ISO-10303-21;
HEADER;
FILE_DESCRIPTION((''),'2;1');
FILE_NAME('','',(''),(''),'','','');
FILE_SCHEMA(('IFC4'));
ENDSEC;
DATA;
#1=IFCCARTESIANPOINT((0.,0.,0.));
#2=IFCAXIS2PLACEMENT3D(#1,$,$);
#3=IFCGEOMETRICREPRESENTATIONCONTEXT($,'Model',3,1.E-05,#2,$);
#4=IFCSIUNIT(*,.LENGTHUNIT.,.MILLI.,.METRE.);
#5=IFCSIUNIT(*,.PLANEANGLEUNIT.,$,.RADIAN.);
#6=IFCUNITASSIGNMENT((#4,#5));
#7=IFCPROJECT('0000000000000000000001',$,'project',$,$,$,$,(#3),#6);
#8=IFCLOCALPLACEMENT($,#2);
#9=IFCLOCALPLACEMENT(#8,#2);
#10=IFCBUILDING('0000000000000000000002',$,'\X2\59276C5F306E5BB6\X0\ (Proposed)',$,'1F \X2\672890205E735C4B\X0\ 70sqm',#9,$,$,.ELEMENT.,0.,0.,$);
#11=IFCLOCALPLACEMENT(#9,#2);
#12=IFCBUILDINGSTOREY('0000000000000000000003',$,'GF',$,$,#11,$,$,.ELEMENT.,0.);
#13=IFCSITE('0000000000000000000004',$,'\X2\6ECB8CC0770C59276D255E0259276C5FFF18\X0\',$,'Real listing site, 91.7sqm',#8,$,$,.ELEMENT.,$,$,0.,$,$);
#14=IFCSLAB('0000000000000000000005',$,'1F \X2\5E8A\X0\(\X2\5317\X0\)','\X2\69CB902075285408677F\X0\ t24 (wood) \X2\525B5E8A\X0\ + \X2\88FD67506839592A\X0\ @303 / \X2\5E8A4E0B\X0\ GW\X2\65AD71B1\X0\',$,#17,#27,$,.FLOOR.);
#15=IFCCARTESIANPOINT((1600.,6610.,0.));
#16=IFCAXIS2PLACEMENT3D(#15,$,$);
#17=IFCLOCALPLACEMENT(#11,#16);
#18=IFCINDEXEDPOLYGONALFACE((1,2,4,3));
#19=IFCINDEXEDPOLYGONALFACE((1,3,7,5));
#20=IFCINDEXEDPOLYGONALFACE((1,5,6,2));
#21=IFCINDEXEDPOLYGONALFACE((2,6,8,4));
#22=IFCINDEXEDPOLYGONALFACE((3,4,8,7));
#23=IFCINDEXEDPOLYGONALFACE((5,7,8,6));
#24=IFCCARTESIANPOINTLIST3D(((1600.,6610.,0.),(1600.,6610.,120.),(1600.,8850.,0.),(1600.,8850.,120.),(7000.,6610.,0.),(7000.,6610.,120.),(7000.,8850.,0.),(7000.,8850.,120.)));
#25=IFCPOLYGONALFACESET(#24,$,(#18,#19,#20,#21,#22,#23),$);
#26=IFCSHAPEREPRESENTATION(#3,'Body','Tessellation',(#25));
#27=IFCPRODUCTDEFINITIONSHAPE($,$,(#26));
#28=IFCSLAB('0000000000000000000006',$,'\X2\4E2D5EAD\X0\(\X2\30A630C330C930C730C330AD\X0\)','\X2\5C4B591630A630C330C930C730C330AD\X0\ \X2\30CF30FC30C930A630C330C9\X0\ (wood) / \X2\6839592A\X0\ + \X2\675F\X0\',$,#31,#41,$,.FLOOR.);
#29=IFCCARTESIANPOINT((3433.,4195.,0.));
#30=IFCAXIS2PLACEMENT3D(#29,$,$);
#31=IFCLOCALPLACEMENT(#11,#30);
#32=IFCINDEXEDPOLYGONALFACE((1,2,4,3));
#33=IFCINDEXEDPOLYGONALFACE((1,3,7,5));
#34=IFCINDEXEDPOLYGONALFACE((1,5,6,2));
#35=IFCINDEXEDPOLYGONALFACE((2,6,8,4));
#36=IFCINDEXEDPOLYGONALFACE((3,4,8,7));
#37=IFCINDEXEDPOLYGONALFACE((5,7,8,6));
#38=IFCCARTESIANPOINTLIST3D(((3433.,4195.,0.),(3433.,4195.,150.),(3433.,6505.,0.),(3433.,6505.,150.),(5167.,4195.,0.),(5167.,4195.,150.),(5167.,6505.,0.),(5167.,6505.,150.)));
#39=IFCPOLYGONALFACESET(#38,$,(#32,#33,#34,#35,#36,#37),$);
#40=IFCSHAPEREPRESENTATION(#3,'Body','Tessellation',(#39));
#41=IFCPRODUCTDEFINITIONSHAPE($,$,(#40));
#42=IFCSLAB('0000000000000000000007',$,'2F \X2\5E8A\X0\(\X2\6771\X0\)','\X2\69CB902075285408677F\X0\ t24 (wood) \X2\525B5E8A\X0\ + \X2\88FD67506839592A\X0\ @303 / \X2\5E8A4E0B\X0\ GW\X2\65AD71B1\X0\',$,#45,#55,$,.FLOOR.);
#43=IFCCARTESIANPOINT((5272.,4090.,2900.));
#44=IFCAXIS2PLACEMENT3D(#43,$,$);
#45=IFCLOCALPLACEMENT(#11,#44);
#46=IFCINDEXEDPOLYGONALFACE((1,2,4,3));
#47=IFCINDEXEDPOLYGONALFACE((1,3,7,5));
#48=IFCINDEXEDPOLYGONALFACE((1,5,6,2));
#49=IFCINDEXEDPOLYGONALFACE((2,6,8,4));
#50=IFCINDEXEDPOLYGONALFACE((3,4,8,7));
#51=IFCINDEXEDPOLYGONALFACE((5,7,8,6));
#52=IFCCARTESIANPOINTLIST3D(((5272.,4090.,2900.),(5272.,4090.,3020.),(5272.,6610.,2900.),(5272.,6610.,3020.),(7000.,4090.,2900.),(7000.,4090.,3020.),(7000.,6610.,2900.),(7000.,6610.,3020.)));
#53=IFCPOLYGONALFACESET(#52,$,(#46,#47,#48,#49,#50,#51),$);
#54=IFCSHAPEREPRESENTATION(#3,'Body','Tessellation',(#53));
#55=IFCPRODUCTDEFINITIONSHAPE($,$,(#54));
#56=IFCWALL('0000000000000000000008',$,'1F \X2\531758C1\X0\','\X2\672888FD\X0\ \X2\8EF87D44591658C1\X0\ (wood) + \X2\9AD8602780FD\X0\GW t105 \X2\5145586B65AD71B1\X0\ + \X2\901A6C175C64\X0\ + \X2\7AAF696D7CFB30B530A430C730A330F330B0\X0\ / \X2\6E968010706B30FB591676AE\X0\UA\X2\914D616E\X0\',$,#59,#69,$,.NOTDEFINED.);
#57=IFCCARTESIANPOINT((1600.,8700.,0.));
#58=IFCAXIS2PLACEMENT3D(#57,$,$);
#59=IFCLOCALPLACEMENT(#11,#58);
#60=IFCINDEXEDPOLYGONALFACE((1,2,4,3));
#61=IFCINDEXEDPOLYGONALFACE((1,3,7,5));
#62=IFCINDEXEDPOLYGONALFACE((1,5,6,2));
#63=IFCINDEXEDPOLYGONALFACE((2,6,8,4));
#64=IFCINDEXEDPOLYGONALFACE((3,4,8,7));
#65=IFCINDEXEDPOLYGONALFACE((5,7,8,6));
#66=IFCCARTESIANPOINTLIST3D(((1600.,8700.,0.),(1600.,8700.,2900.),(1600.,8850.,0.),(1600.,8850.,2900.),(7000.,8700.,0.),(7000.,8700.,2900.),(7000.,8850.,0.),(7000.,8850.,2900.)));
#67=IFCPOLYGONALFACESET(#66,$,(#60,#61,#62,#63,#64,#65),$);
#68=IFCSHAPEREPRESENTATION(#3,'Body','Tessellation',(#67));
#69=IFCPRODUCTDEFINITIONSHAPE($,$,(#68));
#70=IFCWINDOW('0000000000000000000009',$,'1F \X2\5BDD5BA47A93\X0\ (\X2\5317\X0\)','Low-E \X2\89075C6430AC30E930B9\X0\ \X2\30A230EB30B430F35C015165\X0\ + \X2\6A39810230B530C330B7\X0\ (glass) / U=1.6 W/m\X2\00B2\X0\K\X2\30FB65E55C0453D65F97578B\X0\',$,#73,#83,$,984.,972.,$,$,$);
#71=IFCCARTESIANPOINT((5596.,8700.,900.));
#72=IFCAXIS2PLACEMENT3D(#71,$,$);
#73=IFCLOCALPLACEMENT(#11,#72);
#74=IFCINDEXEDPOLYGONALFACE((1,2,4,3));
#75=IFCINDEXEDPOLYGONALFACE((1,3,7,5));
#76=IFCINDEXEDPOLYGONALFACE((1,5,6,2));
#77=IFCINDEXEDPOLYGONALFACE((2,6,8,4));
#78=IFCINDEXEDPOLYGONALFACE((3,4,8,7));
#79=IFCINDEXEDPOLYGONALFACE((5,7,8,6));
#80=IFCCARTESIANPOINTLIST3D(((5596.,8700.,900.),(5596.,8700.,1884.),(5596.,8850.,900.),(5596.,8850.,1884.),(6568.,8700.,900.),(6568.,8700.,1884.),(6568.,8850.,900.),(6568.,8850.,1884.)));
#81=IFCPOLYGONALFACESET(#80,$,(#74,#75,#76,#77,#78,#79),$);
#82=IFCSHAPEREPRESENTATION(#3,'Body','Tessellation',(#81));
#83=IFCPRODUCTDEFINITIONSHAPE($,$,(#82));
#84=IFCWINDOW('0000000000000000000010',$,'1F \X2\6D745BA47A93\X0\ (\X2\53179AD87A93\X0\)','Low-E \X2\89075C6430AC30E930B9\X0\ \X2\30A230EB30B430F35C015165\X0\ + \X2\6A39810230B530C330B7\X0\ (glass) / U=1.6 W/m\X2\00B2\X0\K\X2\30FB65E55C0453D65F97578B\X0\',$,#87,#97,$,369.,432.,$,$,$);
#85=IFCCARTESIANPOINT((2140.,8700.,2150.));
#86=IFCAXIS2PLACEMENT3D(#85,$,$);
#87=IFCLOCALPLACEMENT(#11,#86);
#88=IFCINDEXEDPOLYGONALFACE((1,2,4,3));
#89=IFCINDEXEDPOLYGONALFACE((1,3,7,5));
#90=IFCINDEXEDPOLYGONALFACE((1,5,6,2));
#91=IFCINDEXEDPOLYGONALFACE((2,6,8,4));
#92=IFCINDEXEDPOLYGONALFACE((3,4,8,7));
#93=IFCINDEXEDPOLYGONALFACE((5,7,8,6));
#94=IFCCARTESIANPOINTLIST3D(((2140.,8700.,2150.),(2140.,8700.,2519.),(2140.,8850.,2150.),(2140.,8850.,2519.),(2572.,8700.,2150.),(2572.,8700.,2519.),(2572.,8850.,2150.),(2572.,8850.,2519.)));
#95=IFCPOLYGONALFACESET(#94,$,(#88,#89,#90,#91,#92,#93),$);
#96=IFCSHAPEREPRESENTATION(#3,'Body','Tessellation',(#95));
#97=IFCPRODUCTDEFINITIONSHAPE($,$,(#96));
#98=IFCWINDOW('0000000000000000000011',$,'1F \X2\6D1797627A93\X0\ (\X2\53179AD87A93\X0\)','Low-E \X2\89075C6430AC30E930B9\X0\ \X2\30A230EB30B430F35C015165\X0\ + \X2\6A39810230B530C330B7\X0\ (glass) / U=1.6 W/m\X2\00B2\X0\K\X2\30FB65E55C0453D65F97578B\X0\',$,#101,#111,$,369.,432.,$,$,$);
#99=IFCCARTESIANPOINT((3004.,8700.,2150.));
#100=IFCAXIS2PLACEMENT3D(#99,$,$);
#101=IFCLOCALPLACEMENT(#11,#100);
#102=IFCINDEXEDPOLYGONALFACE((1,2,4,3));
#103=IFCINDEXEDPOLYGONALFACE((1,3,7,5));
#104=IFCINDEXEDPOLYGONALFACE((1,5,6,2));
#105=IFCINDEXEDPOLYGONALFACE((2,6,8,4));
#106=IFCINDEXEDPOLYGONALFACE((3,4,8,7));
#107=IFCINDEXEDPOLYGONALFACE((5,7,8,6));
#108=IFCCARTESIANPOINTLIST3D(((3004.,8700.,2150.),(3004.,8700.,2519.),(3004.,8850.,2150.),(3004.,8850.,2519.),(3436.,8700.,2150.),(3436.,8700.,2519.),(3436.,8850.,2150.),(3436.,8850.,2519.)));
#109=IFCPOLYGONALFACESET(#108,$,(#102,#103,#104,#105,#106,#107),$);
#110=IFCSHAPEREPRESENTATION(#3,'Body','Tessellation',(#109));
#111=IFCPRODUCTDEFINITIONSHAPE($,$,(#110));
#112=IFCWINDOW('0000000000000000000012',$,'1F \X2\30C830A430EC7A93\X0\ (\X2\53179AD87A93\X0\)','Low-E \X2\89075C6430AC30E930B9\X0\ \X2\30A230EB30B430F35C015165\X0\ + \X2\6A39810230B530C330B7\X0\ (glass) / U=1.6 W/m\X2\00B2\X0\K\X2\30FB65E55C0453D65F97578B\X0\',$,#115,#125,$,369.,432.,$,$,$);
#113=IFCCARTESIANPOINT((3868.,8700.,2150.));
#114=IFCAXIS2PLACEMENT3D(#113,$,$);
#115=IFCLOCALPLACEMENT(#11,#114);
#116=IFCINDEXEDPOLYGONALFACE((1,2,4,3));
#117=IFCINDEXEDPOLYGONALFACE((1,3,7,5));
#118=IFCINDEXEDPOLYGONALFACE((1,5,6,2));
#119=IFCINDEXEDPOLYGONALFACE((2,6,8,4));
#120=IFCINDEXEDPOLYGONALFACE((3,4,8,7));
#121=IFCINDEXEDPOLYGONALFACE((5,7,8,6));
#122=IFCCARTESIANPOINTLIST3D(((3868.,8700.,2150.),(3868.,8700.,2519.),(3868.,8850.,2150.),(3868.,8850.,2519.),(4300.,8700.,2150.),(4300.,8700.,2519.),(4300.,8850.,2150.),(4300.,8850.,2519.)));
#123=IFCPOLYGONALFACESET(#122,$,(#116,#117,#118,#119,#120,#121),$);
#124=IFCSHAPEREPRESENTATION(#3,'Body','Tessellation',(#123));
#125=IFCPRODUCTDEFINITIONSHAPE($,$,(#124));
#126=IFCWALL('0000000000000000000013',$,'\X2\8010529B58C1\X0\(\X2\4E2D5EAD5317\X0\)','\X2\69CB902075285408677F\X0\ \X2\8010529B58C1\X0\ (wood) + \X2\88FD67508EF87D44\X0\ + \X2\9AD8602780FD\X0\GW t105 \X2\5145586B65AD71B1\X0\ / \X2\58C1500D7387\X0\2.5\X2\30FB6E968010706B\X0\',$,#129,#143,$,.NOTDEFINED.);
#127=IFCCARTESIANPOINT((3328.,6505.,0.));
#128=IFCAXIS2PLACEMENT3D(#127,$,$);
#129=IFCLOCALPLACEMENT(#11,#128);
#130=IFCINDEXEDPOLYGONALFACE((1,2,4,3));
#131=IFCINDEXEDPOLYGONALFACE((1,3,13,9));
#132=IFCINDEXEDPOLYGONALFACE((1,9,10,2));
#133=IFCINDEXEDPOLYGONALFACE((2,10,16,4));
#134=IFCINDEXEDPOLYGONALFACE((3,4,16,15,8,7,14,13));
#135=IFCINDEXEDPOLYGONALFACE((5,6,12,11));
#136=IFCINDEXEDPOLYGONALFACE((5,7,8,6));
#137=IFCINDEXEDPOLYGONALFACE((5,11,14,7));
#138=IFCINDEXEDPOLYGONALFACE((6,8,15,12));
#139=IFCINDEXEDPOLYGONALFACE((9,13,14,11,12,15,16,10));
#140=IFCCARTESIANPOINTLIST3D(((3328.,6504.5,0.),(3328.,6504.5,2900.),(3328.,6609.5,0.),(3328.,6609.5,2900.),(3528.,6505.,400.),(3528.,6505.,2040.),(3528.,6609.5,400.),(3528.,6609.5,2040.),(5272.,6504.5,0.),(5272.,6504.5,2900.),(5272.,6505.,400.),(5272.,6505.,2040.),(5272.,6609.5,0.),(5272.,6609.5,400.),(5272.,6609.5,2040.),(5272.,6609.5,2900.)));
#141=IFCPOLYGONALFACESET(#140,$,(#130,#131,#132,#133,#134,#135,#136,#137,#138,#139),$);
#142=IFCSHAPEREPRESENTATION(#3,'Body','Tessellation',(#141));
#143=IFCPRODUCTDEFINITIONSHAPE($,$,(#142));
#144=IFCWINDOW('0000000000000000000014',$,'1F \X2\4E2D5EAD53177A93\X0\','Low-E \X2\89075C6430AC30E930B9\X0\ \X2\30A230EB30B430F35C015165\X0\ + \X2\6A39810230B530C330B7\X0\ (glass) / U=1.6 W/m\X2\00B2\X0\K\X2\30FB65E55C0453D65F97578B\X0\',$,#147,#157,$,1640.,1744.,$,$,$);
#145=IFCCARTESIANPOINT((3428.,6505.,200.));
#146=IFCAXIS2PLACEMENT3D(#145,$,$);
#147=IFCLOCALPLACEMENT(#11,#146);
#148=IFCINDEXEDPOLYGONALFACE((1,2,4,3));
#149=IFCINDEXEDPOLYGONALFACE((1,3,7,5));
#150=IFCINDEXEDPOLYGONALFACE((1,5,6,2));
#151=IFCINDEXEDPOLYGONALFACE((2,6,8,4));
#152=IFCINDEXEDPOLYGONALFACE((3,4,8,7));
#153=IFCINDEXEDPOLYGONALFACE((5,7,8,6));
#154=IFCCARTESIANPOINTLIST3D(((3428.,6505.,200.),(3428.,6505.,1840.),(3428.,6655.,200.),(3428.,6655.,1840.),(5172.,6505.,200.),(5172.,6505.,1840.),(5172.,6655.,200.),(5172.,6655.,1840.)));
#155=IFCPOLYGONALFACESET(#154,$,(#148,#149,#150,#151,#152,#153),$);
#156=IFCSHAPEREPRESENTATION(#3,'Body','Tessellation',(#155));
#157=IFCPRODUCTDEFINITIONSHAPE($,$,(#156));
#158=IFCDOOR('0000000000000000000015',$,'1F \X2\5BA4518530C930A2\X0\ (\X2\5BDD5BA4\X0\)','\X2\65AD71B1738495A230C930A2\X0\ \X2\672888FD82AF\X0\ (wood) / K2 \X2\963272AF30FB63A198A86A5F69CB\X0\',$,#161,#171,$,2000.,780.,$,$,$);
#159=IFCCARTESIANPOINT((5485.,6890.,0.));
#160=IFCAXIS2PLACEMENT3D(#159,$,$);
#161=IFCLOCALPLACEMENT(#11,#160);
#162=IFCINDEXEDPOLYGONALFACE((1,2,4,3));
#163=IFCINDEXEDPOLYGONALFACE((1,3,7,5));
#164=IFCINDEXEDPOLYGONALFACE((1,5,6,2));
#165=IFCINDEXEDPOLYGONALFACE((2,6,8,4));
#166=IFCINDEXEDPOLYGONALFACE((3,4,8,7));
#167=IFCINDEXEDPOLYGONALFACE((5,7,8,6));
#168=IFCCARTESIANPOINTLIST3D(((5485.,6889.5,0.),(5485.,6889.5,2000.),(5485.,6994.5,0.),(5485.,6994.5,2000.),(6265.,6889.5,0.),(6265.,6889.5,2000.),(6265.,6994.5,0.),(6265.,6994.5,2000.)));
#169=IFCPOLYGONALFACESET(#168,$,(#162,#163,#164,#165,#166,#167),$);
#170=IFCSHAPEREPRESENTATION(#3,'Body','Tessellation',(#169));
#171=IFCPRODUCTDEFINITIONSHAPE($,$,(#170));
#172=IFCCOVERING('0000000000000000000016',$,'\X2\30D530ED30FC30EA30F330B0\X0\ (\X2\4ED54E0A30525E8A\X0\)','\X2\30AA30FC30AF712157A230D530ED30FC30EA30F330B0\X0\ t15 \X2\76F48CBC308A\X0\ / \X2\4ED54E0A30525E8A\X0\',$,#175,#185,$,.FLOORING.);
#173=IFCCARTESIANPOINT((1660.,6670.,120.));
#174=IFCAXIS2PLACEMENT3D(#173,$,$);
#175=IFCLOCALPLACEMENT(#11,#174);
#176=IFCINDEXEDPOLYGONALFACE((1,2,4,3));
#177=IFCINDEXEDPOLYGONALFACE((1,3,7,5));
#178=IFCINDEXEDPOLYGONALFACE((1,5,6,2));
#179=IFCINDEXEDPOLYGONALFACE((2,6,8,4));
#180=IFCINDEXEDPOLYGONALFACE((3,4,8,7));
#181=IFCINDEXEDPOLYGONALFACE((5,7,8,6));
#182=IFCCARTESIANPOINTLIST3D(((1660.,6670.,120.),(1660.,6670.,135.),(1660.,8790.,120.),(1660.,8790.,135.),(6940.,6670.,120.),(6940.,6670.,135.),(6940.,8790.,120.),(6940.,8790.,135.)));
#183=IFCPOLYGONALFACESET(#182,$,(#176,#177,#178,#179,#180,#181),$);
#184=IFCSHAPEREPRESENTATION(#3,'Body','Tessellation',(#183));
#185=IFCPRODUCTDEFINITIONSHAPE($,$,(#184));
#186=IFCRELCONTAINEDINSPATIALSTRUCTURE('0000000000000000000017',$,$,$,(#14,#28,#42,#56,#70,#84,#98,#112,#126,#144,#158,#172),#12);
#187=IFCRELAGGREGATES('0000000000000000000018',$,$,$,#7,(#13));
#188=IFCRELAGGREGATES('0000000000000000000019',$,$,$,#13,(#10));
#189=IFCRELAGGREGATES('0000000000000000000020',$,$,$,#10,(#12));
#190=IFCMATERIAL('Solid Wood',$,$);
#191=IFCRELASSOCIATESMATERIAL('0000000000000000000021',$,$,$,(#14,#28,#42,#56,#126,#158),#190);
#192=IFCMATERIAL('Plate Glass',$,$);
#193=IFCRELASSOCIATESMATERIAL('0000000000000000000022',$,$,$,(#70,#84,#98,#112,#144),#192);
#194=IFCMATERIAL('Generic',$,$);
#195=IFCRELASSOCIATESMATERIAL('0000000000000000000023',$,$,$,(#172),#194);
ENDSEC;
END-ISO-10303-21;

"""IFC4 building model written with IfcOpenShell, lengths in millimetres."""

from ifc_helpers import new_model, si_unit, frame, frame_2d, origin, place, context, project, spatial, rectangle, extrude, material, element, fill, save


model = new_model("IFC4")

# Units and contexts
model_context = context("Model", 3, precision=1e-05, world=origin())
ifc_project = project(units=[si_unit("LENGTHUNIT", "METRE", prefix="MILLI"), si_unit("PLANEANGLEUNIT", "RADIAN")], contexts=[model_context])

# Site, building, storey
site_placement = place(None, origin())
site = spatial("IfcSite", under=ifc_project, at=site_placement, Name="滋賀県大津市大江８", ObjectType="Real listing site, 91.7sqm", CompositionType="ELEMENT", RefElevation=0.0)
building_placement = place(site_placement, origin())
building = spatial("IfcBuilding", under=site, at=building_placement, Name="大江の家 (Proposed)", ObjectType="1F 木造平屋 70sqm", CompositionType="ELEMENT", ElevationOfRefHeight=0.0, ElevationOfTerrain=0.0)
storey_placement = place(building_placement, origin())
storey = spatial("IfcBuildingStorey", under=building, at=storey_placement, Name="GF", CompositionType="ELEMENT", Elevation=0.0)

# Slabs
ifc_material_1 = material(Name="Solid Wood")
slab_1_placement = place(storey_placement, frame((1600.0, 6610.0, 0.0)))
element("IfcSlab", 1, at=slab_1_placement, inside=storey, material=ifc_material_1, Name="1F 床(北)", Description="構造用合板 t24 (wood) 剛床 + 製材根太 @303 / 床下 GW断熱", PredefinedType="FLOOR", context=model_context, shape_type="SweptSolid", body=[
    extrude(rectangle(XDim=5400.0, YDim=2240.0, at=frame_2d((2700.0, 1120.0))), frame((1600.0, 6610.0, 0.0)), (0.0, 0.0, 1.0), 120.0),
])
slab_2_placement = place(storey_placement, frame((3433.0, 4195.0, 0.0)))
element("IfcSlab", 2, at=slab_2_placement, inside=storey, material=ifc_material_1, Name="中庭(ウッドデッキ)", Description="屋外ウッドデッキ ハードウッド (wood) / 根太 + 束", PredefinedType="FLOOR", context=model_context, shape_type="SweptSolid", body=[
    extrude(rectangle(XDim=1734.0, YDim=2310.0, at=frame_2d((867.0, 1155.0))), frame((3433.0, 4195.0, 0.0)), (0.0, 0.0, 1.0), 150.0),
])
slab_3_placement = place(storey_placement, frame((5272.0, 4090.0, 2900.0)))
element("IfcSlab", 3, at=slab_3_placement, inside=storey, material=ifc_material_1, Name="2F 床(東)", Description="構造用合板 t24 (wood) 剛床 + 製材根太 @303 / 床下 GW断熱", PredefinedType="FLOOR", context=model_context, shape_type="SweptSolid", body=[
    extrude(rectangle(XDim=1728.0, YDim=2520.0, at=frame_2d((864.0, 1260.0))), frame((5272.0, 4090.0, 2900.0)), (0.0, 0.0, 1.0), 120.0),
])

# Wall, openings, windows
wall_1_placement = place(storey_placement, frame((1600.0, 8700.0, 0.0)))
wall_1 = element("IfcWall", 4, at=wall_1_placement, inside=storey, material=ifc_material_1, Name="1F 北壁", Description="木製 軸組外壁 (wood) + 高性能GW t105 充填断熱 + 通気層 + 窯業系サイディング / 準耐火・外皮UA配慮", PredefinedType="NOTDEFINED", context=model_context, shape_type="SweptSolid", body=[
    extrude(rectangle(XDim=5400.0, YDim=150.0, at=frame_2d((2700.0, 75.0))), frame((1600.0, 8700.0, 0.0)), (0.0, 0.0, 1.0), 2900.0),
])
opening_1_placement = place(storey_placement, frame((5596.0, 8700.0, 900.0)))
opening_1 = element("IfcOpeningElement", 5, at=opening_1_placement, cuts=wall_1, PredefinedType="NOTDEFINED", context=model_context, shape_type="SweptSolid", body=[
    extrude(rectangle(XDim=972.0, YDim=150.0, at=frame_2d((486.0, 75.0))), frame((5596.0, 8700.0, 900.0)), (0.0, 0.0, 1.0), 984.0),
])
opening_2_placement = place(storey_placement, frame((2140.0, 8700.0, 2150.0)))
opening_2 = element("IfcOpeningElement", 6, at=opening_2_placement, cuts=wall_1, PredefinedType="NOTDEFINED", context=model_context, shape_type="SweptSolid", body=[
    extrude(rectangle(XDim=432.0, YDim=150.0, at=frame_2d((216.0, 75.0))), frame((2140.0, 8700.0, 2150.0)), (0.0, 0.0, 1.0), 369.0),
])
opening_3_placement = place(storey_placement, frame((3004.0, 8700.0, 2150.0)))
opening_3 = element("IfcOpeningElement", 7, at=opening_3_placement, cuts=wall_1, PredefinedType="NOTDEFINED", context=model_context, shape_type="SweptSolid", body=[
    extrude(rectangle(XDim=432.0, YDim=150.0, at=frame_2d((216.0, 75.0))), frame((3004.0, 8700.0, 2150.0)), (0.0, 0.0, 1.0), 369.0),
])
opening_4_placement = place(storey_placement, frame((3868.0, 8700.0, 2150.0)))
opening_4 = element("IfcOpeningElement", 8, at=opening_4_placement, cuts=wall_1, PredefinedType="NOTDEFINED", context=model_context, shape_type="SweptSolid", body=[
    extrude(rectangle(XDim=432.0, YDim=150.0, at=frame_2d((216.0, 75.0))), frame((3868.0, 8700.0, 2150.0)), (0.0, 0.0, 1.0), 369.0),
])
ifc_material_2 = material(Name="Plate Glass")
window_1_placement = place(storey_placement, frame((5596.0, 8700.0, 900.0)))
window_1 = element("IfcWindow", 9, at=window_1_placement, inside=storey, material=ifc_material_2, Name="1F 寝室窓 (北)", Description="Low-E 複層ガラス アルゴン封入 + 樹脂サッシ (glass) / U=1.6 W/m²K・日射取得型", OverallHeight=984.0, OverallWidth=972.0, context=model_context, shape_type="SweptSolid", body=[
    extrude(rectangle(XDim=972.0, YDim=150.0, at=frame_2d((486.0, 75.0))), frame((5596.0, 8700.0, 900.0)), (0.0, 0.0, 1.0), 984.0),
])
fill(opening_1, window_1)
window_2_placement = place(storey_placement, frame((2140.0, 8700.0, 2150.0)))
window_2 = element("IfcWindow", 10, at=window_2_placement, inside=storey, material=ifc_material_2, Name="1F 浴室窓 (北高窓)", Description="Low-E 複層ガラス アルゴン封入 + 樹脂サッシ (glass) / U=1.6 W/m²K・日射取得型", OverallHeight=369.0, OverallWidth=432.0, context=model_context, shape_type="SweptSolid", body=[
    extrude(rectangle(XDim=432.0, YDim=150.0, at=frame_2d((216.0, 75.0))), frame((2140.0, 8700.0, 2150.0)), (0.0, 0.0, 1.0), 369.0),
])
fill(opening_2, window_2)
window_3_placement = place(storey_placement, frame((3004.0, 8700.0, 2150.0)))
window_3 = element("IfcWindow", 11, at=window_3_placement, inside=storey, material=ifc_material_2, Name="1F 洗面窓 (北高窓)", Description="Low-E 複層ガラス アルゴン封入 + 樹脂サッシ (glass) / U=1.6 W/m²K・日射取得型", OverallHeight=369.0, OverallWidth=432.0, context=model_context, shape_type="SweptSolid", body=[
    extrude(rectangle(XDim=432.0, YDim=150.0, at=frame_2d((216.0, 75.0))), frame((3004.0, 8700.0, 2150.0)), (0.0, 0.0, 1.0), 369.0),
])
fill(opening_3, window_3)
window_4_placement = place(storey_placement, frame((3868.0, 8700.0, 2150.0)))
window_4 = element("IfcWindow", 12, at=window_4_placement, inside=storey, material=ifc_material_2, Name="1F トイレ窓 (北高窓)", Description="Low-E 複層ガラス アルゴン封入 + 樹脂サッシ (glass) / U=1.6 W/m²K・日射取得型", OverallHeight=369.0, OverallWidth=432.0, context=model_context, shape_type="SweptSolid", body=[
    extrude(rectangle(XDim=432.0, YDim=150.0, at=frame_2d((216.0, 75.0))), frame((3868.0, 8700.0, 2150.0)), (0.0, 0.0, 1.0), 369.0),
])
fill(opening_4, window_4)

# Wall, opening, window
wall_2_placement = place(storey_placement, frame((3328.0, 6505.0, 0.0)))
wall_2 = element("IfcWall", 13, at=wall_2_placement, inside=storey, material=ifc_material_1, Name="耐力壁(中庭北)", Description="構造用合板 耐力壁 (wood) + 製材軸組 + 高性能GW t105 充填断熱 / 壁倍率2.5・準耐火", PredefinedType="NOTDEFINED", context=model_context, shape_type="SweptSolid", body=[
    extrude(rectangle(XDim=1944.0, YDim=105.0, at=frame_2d((972.0, 52.0))), frame((3328.0, 6505.0, 0.0)), (0.0, 0.0, 1.0), 2900.0),
])
opening_5_placement = place(storey_placement, frame((3428.0, 6505.0, 200.0)))
opening_5 = element("IfcOpeningElement", 14, at=opening_5_placement, cuts=wall_2, PredefinedType="NOTDEFINED", context=model_context, shape_type="SweptSolid", body=[
    extrude(rectangle(XDim=1744.0, YDim=150.0, at=frame_2d((872.0, 75.0))), frame((3428.0, 6505.0, 200.0)), (0.0, 0.0, 1.0), 1640.0),
])
window_5_placement = place(storey_placement, frame((3428.0, 6505.0, 200.0)))
window_5 = element("IfcWindow", 15, at=window_5_placement, inside=storey, material=ifc_material_2, Name="1F 中庭北窓", Description="Low-E 複層ガラス アルゴン封入 + 樹脂サッシ (glass) / U=1.6 W/m²K・日射取得型", OverallHeight=1640.0, OverallWidth=1744.0, context=model_context, shape_type="SweptSolid", body=[
    extrude(rectangle(XDim=1744.0, YDim=150.0, at=frame_2d((872.0, 75.0))), frame((3428.0, 6505.0, 200.0)), (0.0, 0.0, 1.0), 1640.0),
])
fill(opening_5, window_5)

# Door
door_1_placement = place(storey_placement, frame((5485.0, 6890.0, 0.0)))
element("IfcDoor", 16, at=door_1_placement, inside=storey, material=ifc_material_1, Name="1F 室内ドア (寝室)", Description="断熱玄関ドア 木製芯 (wood) / K2 防犯・採風機構", OverallHeight=2000.0, OverallWidth=780.0, context=model_context, shape_type="SweptSolid", body=[
    extrude(rectangle(XDim=780.0, YDim=105.0, at=frame_2d((390.0, 52.0))), frame((5485.0, 6890.0, 0.0)), (0.0, 0.0, 1.0), 2000.0),
])

# Covering
ifc_material_3 = material(Name="Generic")
covering_1_placement = place(storey_placement, frame((1660.0, 6670.0, 120.0)))
element("IfcCovering", 17, at=covering_1_placement, inside=storey, material=ifc_material_3, Name="フローリング (仕上げ床)", Description="オーク無垢フローリング t15 直貼り / 仕上げ床", PredefinedType="FLOORING", context=model_context, shape_type="SweptSolid", body=[
    extrude(rectangle(XDim=5280.0, YDim=2120.0, at=frame_2d((2640.0, 1060.0))), frame((1660.0, 6670.0, 120.0)), (0.0, 0.0, 1.0), 15.0),
])

save(model, "model.ifc")
